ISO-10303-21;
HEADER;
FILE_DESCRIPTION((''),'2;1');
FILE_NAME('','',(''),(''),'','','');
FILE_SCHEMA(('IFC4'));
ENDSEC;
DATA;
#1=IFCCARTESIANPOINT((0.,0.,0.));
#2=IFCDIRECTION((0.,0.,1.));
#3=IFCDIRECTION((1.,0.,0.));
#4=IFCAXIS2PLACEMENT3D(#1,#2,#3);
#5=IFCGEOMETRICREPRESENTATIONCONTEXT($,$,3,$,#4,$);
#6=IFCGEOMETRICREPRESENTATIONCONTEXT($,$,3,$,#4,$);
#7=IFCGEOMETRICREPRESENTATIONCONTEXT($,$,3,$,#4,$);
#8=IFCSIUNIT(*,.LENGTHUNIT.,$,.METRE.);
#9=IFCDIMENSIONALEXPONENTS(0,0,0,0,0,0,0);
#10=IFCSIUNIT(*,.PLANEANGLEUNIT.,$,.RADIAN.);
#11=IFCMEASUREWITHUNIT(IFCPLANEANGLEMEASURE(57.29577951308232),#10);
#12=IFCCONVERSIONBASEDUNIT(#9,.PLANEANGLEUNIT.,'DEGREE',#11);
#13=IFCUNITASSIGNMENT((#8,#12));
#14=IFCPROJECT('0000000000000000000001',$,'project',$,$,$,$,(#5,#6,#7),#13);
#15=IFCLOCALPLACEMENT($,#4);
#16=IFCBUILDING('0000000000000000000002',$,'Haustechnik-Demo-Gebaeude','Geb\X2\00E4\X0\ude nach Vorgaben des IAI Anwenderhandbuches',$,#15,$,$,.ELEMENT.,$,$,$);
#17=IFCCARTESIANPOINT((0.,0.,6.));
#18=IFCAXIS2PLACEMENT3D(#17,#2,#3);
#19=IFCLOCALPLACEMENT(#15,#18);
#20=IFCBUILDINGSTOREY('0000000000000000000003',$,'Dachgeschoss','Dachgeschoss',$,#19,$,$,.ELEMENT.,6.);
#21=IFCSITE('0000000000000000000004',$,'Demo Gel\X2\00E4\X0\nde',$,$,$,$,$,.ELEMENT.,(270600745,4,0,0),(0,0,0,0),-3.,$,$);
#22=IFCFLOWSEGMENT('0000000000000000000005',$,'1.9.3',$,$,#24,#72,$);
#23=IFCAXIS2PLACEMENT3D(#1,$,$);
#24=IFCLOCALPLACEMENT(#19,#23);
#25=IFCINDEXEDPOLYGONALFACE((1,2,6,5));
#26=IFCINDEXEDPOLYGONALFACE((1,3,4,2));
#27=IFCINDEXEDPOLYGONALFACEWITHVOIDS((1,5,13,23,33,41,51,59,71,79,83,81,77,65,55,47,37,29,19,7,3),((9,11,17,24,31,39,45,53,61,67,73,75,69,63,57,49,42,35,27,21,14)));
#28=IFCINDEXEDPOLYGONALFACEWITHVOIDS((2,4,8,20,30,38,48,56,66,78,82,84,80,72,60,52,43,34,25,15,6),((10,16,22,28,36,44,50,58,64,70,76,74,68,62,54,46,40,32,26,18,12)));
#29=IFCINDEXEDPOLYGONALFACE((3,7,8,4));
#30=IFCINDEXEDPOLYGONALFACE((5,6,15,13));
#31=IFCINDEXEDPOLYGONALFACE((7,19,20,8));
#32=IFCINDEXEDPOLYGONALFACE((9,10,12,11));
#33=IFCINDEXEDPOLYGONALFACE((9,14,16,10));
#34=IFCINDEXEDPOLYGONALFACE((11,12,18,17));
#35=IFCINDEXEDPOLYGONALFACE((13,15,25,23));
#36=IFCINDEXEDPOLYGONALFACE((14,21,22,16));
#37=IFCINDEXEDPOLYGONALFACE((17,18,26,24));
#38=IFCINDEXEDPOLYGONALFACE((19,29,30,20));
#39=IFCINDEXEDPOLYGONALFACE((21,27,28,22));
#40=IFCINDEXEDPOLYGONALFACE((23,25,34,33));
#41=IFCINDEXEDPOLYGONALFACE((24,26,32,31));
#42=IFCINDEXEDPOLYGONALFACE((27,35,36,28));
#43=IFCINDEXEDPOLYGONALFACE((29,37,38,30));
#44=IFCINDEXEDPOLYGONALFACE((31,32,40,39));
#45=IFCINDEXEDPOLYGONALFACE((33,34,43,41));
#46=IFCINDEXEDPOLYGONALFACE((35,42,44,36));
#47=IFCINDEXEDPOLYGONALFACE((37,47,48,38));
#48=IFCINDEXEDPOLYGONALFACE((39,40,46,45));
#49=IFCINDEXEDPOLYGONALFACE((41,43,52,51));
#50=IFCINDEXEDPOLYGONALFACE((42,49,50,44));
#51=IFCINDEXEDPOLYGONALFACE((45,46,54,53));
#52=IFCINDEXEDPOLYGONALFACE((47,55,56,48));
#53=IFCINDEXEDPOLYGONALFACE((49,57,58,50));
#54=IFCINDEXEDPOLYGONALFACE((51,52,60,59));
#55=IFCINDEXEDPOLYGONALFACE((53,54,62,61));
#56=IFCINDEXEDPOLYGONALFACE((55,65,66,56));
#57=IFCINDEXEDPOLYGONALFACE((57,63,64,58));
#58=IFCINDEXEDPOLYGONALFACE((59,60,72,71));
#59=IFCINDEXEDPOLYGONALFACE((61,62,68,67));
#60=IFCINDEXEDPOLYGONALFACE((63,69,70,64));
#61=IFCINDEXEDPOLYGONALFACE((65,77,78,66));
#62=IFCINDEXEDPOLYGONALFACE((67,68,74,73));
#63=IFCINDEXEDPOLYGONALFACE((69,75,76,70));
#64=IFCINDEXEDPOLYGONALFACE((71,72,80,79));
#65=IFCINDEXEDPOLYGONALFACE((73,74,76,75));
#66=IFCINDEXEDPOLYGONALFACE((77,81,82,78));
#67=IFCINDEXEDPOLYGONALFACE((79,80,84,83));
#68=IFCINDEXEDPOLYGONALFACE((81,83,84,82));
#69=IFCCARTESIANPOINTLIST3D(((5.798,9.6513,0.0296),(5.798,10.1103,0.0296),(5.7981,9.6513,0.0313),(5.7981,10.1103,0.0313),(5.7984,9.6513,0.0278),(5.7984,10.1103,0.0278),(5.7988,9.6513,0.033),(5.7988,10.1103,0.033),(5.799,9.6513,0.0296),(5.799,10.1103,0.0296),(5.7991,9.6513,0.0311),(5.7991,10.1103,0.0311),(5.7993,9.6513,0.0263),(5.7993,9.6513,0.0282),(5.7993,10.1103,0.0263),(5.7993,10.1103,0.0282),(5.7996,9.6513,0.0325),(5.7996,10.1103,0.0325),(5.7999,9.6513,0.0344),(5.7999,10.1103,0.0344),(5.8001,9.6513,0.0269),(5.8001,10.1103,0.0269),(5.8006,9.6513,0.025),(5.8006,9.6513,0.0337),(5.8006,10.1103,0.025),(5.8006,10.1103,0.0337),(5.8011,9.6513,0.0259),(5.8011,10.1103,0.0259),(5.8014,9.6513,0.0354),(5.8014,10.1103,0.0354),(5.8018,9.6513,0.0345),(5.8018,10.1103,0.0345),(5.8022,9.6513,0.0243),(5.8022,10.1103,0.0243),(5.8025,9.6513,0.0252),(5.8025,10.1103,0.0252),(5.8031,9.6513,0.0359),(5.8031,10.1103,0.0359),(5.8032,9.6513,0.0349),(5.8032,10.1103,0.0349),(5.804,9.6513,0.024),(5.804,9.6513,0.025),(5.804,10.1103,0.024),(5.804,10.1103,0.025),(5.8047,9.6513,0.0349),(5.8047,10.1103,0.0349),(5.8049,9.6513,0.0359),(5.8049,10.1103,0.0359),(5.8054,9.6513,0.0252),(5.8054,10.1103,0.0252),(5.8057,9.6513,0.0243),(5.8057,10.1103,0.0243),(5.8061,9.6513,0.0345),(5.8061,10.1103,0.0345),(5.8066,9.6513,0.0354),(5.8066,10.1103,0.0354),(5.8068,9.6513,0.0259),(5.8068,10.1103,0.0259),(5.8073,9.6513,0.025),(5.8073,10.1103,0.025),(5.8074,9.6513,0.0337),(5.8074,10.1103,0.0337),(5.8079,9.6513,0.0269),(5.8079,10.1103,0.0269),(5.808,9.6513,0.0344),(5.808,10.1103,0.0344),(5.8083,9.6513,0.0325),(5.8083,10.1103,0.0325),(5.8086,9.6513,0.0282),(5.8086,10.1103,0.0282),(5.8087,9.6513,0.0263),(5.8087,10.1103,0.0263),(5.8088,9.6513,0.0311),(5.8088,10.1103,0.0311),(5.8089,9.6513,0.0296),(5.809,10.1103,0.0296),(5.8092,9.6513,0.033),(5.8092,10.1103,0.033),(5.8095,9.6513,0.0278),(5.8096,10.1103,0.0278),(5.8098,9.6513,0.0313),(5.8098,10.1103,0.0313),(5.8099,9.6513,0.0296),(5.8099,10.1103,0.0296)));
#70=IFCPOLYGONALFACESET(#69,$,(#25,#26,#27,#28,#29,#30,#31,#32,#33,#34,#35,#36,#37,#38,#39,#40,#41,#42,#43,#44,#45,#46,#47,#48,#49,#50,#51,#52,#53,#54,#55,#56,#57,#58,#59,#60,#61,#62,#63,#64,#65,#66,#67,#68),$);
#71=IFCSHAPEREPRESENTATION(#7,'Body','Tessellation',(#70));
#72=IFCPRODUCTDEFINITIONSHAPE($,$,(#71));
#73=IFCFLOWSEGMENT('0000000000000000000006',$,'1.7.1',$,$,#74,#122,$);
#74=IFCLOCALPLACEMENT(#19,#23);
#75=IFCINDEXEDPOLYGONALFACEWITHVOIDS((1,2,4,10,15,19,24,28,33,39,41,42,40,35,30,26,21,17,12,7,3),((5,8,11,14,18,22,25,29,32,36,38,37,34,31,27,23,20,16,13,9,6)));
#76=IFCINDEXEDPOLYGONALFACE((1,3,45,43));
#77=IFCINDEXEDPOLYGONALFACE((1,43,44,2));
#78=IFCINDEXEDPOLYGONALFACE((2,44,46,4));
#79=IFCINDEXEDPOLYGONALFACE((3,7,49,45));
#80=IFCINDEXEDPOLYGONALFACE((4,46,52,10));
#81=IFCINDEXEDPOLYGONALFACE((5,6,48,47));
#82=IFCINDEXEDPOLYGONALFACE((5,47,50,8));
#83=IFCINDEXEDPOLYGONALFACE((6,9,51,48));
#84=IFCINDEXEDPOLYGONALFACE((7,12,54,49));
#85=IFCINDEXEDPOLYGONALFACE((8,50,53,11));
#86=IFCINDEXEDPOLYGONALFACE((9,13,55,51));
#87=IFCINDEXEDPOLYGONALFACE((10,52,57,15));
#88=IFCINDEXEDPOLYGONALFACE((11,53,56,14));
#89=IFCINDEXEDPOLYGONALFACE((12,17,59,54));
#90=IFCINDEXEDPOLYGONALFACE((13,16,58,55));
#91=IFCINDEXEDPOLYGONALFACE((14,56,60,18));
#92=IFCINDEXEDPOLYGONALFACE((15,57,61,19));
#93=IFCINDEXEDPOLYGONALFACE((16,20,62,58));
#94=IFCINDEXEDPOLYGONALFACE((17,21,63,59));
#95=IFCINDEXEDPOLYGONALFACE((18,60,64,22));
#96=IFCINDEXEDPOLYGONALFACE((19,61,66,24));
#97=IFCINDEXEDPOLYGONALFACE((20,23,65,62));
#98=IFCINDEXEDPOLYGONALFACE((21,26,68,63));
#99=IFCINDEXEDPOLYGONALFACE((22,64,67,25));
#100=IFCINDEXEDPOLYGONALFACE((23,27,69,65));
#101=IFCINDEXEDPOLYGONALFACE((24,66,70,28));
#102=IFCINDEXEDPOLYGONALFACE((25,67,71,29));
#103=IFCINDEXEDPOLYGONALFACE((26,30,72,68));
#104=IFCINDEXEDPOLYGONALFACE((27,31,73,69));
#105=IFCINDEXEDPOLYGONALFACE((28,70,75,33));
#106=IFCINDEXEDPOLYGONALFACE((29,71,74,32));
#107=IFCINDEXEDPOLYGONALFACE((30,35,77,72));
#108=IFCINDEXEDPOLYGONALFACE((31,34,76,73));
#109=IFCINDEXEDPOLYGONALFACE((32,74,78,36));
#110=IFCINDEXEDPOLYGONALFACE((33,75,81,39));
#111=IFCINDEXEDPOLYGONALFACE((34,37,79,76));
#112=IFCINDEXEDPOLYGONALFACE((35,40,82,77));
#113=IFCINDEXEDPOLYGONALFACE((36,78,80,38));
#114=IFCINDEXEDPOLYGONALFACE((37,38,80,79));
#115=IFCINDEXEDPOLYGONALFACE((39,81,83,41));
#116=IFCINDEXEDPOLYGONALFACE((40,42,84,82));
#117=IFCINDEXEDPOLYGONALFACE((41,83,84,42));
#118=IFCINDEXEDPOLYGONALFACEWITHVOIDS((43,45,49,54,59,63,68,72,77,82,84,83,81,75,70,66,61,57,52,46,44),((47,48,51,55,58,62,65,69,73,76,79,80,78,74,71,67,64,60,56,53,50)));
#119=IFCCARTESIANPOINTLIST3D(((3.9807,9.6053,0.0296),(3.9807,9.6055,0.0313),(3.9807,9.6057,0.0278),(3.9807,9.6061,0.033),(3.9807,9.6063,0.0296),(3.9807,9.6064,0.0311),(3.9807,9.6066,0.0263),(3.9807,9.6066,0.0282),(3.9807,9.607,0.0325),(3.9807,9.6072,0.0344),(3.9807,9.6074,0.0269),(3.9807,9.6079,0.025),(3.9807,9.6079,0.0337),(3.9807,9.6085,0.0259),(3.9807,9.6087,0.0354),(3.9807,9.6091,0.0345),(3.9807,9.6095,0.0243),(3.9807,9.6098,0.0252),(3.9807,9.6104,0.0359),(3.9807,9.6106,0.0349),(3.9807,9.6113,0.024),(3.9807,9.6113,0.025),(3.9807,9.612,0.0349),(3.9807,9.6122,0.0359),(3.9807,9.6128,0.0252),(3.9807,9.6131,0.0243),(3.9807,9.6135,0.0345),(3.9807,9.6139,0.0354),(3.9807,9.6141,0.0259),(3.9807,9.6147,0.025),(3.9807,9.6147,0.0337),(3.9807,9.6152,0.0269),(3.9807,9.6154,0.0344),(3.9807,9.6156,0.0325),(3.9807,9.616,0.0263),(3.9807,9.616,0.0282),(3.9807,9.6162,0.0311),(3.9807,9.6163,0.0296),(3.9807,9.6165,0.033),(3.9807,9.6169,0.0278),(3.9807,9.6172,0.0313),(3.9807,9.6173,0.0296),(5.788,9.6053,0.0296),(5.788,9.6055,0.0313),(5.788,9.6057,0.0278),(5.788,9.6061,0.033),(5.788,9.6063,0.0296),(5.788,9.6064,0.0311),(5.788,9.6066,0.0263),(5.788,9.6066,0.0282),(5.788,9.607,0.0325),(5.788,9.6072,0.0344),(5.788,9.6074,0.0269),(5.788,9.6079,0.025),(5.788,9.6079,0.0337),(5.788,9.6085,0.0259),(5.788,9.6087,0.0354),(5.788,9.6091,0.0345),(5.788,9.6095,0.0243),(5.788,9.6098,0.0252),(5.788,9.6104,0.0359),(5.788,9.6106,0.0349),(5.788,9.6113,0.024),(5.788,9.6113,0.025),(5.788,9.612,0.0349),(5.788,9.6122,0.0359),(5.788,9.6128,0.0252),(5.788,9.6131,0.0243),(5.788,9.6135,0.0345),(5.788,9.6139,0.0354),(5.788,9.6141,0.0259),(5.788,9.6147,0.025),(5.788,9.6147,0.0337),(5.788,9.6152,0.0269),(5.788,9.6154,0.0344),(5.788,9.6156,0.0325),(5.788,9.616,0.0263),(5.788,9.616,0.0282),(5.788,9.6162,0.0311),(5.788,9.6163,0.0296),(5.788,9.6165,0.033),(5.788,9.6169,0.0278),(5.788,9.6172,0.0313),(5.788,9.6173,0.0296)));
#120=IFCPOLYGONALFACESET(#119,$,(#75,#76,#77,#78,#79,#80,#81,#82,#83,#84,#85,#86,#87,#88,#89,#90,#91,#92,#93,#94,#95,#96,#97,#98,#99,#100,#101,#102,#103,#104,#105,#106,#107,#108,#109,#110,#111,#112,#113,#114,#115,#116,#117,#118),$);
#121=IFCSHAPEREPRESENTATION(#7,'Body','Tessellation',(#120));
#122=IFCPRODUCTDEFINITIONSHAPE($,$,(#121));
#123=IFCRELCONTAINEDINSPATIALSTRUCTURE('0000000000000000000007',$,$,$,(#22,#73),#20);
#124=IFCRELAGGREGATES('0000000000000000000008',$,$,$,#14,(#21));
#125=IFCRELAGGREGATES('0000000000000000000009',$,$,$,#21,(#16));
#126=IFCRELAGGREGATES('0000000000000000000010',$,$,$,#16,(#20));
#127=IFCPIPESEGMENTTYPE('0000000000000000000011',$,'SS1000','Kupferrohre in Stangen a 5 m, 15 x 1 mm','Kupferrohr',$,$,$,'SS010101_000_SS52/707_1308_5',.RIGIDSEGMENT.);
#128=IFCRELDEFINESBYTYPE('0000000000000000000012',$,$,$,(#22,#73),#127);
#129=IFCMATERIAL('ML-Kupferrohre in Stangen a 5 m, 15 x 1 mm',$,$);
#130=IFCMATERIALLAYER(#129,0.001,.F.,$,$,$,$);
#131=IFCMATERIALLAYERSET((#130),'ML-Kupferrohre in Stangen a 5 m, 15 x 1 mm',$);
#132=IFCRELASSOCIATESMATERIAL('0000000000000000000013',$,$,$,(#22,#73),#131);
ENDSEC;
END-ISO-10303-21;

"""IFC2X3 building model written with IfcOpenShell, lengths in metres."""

from ifc_helpers import new_model, entity, si_unit, converted_unit, frame, origin_with_axes, origin_2d_with_axis, place, context, project, spatial, hollow_circle, extrude, material, layer, layer_set, layer_usage, type_object, element, save


model = new_model("IFC2X3")

# Units and contexts
context_of_model_1 = context(None, 3, world=origin_with_axes())
context_of_model_2 = context(None, 3, world=origin_with_axes())
context_of_model_3 = context(None, 3, world=origin_with_axes())
ifc_project = project(units=[si_unit("LENGTHUNIT", "METRE"), converted_unit("PLANEANGLEUNIT", "DEGREE", entity("IfcPlaneAngleMeasure", 57.29577951308232), si_unit("PLANEANGLEUNIT", "RADIAN"), dimensions=[0, 0, 0, 0, 0, 0, 0])], contexts=[context_of_model_1, context_of_model_2, context_of_model_3])

# Site, building, storey
site = spatial("IfcSite", under=ifc_project, Name="Demo Gelände", CompositionType="ELEMENT", RefLatitude=(270600745, 4, 0, 0), RefLongitude=(0, 0, 0, 0), RefElevation=-3.0)
building_placement = place(None, origin_with_axes())
building = spatial("IfcBuilding", under=site, at=building_placement, Name="Haustechnik-Demo-Gebaeude", Description="Gebäude nach Vorgaben des IAI Anwenderhandbuches", CompositionType="ELEMENT")
storey_placement = place(building_placement, frame((0.0, 0.0, 6.0), z_axis=(0.0, 0.0, 1.0), x_axis=(1.0, 0.0, 0.0)))
storey = spatial("IfcBuildingStorey", under=building, at=storey_placement, Name="Dachgeschoss", Description="Dachgeschoss", CompositionType="ELEMENT", Elevation=6.0)

# Flow segments
ifc_material = material(Name="ML-Kupferrohre in Stangen a 5 m, 15 x 1 mm")
ifc_layer = layer(ifc_material, 0.001, ventilated=False)
ifc_layer_set = layer_set([ifc_layer], Name="ML-Kupferrohre in Stangen a 5 m, 15 x 1 mm")
ifc_layer_usage = layer_usage(ifc_layer_set, "AXIS2", "POSITIVE", 0.0)
pipe_segment_type_1 = type_object("IfcPipeSegmentType", Name="SS1000", Description="Kupferrohre in Stangen a 5 m, 15 x 1 mm", ApplicableOccurrence="Kupferrohr", ElementType="SS010101_000_SS52/707_1308_5", PredefinedType="RIGIDSEGMENT")
flow_segment_1_placement = place(storey_placement, frame((5.804, 10.1103, 0.03), z_axis=(-0.00001, -1.0, 0.0), x_axis=(0.0, 0.0, -1.0)))
element("IfcFlowSegment", 1, at=flow_segment_1_placement, inside=storey, type_object=pipe_segment_type_1, material=ifc_layer_usage, Name="1.9.3", context=context_of_model_3, shape_type="SweptSolid", body=[
    extrude(hollow_circle(Radius=0.006, WallThickness=0.001, at=origin_2d_with_axis()), origin_with_axes(), (0.0, 0.0, 1.0), 0.459),
])
flow_segment_2_placement = place(storey_placement, frame((5.788, 9.6113, 0.03), z_axis=(-1.0, 0.0, 0.0), x_axis=(0.0, 0.0, -1.0)))
element("IfcFlowSegment", 2, at=flow_segment_2_placement, inside=storey, type_object=pipe_segment_type_1, material=ifc_layer_usage, Name="1.7.1", context=context_of_model_3, shape_type="SweptSolid", body=[
    extrude(hollow_circle(Radius=0.006, WallThickness=0.001, at=origin_2d_with_axis()), origin_with_axes(), (0.0, 0.0, 1.0), 1.8073),
])

save(model, "model.ifc")
